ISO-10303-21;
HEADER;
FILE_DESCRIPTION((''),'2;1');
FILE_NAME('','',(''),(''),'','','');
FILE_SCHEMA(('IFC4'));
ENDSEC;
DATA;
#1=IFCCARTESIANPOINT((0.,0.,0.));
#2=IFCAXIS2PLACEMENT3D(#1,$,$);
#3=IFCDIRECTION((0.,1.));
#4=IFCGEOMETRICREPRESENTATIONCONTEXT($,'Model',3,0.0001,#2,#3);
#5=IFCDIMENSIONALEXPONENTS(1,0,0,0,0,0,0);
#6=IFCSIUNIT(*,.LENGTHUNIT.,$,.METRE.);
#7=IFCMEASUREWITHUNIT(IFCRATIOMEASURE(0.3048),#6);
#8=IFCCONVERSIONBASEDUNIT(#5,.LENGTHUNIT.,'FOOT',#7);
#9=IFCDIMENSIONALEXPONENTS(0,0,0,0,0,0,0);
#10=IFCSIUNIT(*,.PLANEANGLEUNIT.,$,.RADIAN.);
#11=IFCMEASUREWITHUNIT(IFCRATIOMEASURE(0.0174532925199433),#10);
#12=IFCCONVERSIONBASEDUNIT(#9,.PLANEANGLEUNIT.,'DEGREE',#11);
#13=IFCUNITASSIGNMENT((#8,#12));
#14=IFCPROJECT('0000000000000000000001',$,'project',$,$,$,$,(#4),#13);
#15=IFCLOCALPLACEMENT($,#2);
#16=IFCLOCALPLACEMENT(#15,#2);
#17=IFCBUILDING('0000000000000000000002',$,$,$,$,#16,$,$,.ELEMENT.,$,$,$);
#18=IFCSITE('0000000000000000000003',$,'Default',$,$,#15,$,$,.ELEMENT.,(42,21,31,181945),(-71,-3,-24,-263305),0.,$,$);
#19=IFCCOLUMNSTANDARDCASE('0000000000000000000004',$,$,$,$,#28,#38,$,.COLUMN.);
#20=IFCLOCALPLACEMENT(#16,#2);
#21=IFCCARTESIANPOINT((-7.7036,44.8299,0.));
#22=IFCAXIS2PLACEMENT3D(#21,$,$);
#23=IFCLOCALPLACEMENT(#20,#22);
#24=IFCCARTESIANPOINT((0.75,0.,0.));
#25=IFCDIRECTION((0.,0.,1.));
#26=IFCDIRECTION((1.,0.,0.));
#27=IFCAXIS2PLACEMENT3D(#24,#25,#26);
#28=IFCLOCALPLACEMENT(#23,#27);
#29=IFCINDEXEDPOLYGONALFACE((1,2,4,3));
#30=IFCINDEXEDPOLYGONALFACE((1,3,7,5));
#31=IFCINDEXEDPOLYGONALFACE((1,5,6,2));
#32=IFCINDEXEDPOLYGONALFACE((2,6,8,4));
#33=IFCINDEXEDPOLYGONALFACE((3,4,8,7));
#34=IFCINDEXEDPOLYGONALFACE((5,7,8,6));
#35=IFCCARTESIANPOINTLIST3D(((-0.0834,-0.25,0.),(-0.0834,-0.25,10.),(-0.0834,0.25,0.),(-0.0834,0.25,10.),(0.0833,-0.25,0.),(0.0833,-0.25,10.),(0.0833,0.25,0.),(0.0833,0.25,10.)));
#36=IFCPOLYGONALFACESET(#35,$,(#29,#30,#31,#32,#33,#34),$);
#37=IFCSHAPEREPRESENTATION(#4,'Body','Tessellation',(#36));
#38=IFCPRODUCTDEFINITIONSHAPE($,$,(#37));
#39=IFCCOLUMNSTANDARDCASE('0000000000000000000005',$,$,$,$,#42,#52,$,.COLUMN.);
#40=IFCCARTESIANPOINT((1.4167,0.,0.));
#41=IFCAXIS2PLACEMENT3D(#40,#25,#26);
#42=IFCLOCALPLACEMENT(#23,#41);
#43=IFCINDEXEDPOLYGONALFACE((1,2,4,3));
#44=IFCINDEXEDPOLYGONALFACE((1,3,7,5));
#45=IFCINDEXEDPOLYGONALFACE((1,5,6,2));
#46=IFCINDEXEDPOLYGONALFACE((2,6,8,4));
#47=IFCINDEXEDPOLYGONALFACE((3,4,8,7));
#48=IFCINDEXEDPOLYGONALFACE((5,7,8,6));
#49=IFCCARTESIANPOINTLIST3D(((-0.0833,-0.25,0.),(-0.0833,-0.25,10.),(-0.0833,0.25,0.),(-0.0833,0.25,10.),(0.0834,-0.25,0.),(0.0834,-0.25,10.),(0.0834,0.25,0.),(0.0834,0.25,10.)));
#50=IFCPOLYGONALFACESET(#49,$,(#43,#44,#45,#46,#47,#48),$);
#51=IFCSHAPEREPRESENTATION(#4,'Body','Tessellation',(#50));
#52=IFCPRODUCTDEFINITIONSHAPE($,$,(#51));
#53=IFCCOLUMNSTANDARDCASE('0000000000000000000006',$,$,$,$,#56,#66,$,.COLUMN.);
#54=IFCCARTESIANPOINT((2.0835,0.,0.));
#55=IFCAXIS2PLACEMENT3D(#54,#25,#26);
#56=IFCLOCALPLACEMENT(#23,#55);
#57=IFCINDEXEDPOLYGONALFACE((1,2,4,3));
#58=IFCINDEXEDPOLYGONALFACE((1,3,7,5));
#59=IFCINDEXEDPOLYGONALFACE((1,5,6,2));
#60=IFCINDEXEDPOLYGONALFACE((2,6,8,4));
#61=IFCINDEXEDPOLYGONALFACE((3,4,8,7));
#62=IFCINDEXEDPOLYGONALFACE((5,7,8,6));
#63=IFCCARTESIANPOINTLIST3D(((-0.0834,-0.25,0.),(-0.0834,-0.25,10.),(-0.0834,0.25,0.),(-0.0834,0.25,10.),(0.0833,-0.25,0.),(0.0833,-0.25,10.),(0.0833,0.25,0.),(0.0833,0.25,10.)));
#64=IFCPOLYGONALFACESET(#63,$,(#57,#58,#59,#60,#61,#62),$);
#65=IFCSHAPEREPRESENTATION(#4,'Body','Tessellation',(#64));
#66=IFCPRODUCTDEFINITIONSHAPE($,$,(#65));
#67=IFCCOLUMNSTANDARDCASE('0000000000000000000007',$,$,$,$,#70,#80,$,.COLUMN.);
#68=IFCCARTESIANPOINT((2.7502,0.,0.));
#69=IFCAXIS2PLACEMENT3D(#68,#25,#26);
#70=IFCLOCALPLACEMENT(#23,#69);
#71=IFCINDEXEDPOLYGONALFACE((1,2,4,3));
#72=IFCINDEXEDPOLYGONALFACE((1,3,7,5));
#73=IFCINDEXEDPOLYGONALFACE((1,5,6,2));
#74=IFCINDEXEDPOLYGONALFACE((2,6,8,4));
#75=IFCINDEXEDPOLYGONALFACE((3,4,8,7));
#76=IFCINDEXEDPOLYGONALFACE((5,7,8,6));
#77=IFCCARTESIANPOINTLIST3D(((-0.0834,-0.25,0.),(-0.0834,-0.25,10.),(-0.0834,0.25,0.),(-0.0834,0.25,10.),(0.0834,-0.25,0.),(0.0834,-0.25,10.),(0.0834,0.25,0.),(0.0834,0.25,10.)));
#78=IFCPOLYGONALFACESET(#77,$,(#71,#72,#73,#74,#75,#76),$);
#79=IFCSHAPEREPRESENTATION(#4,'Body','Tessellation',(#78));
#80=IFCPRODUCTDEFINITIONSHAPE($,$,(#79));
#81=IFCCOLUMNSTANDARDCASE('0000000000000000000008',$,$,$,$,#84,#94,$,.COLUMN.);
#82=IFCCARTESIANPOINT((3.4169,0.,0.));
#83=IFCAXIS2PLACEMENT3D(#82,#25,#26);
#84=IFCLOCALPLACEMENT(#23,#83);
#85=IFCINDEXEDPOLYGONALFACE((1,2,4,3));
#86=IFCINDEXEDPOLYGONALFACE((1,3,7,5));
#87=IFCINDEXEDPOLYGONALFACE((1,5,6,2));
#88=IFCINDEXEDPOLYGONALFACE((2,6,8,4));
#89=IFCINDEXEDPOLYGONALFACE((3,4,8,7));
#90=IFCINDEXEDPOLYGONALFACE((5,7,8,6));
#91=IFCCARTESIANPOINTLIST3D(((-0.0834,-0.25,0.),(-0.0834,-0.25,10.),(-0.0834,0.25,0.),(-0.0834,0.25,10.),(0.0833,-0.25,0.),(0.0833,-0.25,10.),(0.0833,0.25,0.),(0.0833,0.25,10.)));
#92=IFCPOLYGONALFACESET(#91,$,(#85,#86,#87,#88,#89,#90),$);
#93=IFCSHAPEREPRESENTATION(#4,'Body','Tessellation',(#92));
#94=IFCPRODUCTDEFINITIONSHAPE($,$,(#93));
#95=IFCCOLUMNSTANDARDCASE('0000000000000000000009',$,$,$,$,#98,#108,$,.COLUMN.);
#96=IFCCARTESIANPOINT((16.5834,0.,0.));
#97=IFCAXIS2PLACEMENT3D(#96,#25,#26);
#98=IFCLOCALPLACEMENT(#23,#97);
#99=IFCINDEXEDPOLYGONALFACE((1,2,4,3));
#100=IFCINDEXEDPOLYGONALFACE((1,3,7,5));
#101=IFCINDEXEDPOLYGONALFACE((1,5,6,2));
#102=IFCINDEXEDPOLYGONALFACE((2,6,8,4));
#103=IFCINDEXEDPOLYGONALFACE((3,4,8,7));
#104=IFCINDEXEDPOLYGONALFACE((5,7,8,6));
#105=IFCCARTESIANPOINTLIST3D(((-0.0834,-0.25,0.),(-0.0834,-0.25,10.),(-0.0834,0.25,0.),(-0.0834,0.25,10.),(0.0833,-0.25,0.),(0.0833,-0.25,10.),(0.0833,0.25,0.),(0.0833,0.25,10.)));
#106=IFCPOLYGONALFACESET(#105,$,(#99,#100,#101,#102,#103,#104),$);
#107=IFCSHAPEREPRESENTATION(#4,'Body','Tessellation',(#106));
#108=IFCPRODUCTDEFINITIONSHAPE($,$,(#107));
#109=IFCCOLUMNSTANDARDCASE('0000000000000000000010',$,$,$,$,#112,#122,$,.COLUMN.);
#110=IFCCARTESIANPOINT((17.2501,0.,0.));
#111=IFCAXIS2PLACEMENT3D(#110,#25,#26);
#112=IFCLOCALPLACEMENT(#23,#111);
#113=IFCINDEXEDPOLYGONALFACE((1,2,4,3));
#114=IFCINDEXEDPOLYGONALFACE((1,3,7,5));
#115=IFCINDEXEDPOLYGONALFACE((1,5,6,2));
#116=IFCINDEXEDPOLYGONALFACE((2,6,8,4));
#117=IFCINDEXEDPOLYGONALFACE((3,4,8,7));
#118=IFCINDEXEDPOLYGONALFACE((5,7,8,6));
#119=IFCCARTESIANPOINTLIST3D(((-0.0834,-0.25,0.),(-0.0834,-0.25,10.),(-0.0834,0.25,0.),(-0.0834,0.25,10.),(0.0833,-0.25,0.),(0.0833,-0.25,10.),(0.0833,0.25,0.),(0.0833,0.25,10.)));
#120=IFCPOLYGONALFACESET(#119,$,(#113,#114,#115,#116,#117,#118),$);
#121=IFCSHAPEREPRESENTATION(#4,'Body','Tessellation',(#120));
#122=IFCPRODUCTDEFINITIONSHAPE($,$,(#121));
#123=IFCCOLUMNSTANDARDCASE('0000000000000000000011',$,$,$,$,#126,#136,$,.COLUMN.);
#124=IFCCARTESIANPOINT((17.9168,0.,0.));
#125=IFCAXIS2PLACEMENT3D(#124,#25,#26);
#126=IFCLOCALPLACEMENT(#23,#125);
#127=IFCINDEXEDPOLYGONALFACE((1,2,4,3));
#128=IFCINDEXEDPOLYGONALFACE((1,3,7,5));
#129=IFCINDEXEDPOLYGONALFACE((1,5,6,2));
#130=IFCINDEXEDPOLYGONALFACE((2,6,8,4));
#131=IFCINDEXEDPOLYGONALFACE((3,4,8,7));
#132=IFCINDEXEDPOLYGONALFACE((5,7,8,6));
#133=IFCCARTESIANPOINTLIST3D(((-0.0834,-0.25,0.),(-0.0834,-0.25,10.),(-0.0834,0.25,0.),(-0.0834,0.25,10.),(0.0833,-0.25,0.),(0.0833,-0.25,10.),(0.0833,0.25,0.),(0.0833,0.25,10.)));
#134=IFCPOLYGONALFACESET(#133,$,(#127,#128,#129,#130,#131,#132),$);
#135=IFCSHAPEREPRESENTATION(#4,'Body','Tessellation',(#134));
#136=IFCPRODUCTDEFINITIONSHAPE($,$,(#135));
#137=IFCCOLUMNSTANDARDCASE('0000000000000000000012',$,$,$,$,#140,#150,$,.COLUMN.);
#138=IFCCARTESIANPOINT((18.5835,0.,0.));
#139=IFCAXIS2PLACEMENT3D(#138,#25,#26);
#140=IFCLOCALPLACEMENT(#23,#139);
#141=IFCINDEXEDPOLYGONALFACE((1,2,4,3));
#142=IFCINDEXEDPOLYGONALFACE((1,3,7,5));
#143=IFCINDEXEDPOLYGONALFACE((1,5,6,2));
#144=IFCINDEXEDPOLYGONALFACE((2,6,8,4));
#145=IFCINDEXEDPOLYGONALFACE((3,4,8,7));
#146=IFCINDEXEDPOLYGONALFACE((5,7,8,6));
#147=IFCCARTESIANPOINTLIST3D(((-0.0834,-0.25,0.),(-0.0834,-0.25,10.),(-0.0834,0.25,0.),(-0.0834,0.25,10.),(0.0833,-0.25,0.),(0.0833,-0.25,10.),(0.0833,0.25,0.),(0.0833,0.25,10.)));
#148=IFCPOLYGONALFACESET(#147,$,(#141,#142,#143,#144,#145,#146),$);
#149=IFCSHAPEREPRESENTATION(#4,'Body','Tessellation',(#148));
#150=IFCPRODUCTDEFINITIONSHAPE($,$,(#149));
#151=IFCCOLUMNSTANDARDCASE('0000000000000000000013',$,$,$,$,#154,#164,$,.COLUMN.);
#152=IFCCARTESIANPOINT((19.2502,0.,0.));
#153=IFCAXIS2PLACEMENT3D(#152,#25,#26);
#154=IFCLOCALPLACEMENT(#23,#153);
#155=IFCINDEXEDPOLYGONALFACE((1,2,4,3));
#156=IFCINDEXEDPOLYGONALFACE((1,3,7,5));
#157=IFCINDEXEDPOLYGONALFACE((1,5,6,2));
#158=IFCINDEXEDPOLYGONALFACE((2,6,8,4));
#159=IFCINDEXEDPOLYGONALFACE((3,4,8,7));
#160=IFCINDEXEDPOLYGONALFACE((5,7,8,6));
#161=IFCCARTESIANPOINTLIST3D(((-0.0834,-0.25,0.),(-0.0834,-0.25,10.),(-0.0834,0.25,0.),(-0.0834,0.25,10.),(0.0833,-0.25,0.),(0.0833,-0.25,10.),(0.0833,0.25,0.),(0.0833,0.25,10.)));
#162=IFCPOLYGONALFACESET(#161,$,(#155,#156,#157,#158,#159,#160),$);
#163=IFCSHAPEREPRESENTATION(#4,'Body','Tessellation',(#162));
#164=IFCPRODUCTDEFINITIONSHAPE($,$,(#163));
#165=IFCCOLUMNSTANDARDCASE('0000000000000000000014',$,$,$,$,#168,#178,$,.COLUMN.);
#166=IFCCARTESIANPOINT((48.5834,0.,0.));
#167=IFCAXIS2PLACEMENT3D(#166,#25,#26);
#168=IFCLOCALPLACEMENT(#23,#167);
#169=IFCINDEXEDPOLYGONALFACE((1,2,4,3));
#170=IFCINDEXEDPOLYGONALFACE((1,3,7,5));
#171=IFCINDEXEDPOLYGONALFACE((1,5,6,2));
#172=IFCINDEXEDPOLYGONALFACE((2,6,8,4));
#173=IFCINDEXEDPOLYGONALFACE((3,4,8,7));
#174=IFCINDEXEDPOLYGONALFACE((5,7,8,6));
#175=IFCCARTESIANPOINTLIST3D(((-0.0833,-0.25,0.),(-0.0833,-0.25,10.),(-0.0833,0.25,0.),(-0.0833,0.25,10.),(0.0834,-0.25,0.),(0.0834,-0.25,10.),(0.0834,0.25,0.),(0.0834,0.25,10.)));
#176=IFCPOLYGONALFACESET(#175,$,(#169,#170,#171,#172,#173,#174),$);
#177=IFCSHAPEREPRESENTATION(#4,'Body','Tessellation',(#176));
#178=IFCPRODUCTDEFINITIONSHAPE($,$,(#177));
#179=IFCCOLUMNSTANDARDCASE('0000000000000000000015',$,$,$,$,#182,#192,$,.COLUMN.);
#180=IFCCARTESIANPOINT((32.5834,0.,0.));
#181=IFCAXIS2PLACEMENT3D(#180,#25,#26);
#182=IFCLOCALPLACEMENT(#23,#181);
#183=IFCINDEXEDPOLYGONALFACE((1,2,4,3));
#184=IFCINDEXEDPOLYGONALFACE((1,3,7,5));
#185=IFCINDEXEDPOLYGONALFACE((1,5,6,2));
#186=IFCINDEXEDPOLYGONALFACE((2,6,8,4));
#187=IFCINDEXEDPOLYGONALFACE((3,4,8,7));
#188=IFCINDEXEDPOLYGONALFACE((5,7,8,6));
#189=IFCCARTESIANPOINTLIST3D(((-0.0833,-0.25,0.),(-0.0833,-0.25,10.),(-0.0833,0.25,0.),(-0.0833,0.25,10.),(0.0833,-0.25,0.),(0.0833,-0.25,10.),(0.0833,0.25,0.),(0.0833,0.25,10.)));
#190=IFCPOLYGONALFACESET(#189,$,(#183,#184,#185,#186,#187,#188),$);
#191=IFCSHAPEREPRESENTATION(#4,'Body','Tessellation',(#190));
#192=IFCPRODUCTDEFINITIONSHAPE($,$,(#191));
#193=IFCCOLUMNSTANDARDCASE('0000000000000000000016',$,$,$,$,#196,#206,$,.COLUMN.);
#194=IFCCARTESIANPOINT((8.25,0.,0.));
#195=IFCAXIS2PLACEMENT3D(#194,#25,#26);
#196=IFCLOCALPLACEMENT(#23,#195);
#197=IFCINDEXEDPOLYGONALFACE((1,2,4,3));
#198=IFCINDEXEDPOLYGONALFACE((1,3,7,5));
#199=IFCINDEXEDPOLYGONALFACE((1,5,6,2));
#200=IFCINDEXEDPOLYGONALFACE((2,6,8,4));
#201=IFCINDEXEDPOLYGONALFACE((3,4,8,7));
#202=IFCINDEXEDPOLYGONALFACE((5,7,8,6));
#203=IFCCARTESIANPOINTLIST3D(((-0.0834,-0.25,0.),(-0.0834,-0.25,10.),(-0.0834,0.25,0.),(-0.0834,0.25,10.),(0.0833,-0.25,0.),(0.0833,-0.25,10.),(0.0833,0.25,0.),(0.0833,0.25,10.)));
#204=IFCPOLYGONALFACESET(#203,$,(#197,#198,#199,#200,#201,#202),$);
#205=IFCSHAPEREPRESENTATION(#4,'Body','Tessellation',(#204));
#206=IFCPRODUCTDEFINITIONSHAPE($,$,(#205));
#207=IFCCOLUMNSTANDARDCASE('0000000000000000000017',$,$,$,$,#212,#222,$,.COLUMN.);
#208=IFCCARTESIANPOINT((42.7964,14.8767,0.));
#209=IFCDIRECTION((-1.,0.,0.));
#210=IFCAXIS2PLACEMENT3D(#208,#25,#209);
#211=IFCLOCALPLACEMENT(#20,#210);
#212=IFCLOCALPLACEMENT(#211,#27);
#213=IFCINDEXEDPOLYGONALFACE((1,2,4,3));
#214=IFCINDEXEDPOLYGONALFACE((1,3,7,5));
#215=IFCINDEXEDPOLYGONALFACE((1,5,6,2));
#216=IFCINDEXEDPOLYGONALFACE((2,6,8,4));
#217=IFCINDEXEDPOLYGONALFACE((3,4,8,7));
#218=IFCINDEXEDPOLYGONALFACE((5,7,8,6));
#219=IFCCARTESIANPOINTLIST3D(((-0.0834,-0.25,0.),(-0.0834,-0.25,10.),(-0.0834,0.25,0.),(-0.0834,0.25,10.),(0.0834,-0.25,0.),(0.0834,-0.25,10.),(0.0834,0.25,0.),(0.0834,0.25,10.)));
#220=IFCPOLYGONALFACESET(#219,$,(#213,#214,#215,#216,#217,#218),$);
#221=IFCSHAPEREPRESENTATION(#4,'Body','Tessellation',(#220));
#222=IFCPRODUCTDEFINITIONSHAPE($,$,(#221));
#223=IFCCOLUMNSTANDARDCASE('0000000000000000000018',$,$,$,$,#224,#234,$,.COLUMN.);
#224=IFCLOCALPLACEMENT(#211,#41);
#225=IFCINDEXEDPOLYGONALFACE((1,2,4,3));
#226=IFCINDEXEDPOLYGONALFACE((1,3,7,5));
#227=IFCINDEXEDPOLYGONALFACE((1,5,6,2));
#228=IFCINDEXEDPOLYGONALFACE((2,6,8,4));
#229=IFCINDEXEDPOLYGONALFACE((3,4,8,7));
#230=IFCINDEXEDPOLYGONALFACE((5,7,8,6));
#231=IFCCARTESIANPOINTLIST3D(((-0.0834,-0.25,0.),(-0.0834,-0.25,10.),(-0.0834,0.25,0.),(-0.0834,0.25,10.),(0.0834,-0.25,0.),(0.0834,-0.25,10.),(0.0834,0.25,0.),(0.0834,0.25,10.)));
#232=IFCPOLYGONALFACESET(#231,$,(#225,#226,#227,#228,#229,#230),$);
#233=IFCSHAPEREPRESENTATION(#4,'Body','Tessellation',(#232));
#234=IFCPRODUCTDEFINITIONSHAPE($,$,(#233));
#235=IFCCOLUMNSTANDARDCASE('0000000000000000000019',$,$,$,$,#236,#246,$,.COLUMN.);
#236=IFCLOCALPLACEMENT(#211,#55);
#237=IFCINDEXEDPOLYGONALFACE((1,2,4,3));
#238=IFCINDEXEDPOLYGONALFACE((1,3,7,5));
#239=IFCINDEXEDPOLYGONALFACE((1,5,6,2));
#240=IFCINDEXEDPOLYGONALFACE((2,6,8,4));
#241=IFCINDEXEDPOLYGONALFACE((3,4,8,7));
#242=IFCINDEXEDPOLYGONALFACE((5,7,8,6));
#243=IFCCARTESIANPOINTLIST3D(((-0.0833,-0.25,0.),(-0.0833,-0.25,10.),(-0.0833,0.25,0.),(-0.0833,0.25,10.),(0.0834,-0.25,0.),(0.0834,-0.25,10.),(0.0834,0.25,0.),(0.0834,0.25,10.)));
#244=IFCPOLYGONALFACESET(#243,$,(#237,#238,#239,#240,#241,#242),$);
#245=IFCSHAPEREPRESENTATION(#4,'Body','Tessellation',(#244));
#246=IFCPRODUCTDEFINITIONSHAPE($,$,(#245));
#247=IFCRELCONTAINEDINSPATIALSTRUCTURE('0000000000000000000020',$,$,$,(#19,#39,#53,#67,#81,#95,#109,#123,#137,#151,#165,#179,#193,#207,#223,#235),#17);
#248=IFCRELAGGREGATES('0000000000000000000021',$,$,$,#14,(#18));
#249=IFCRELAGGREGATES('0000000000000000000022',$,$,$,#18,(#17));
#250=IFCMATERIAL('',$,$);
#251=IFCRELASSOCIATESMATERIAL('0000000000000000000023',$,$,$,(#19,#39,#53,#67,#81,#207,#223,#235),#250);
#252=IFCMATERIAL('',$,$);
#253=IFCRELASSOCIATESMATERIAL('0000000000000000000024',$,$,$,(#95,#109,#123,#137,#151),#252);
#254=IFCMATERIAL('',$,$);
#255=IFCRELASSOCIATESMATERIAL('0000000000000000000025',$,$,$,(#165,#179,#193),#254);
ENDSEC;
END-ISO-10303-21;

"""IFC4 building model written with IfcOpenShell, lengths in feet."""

from ifc_helpers import new_model, entity, si_unit, converted_unit, direction, frame, origin, place, context, project, spatial, rectangle, extrude, material, element, save


model = new_model("IFC4")

# Units and contexts
model_context = context("Model", 3, precision=0.0001, world=origin(), true_north=direction((0.0, 1.0)))
ifc_project = project(units=[converted_unit("LENGTHUNIT", "FOOT", entity("IfcRatioMeasure", 0.3048), si_unit("LENGTHUNIT", "METRE"), dimensions=[1, 0, 0, 0, 0, 0, 0]), converted_unit("PLANEANGLEUNIT", "DEGREE", entity("IfcRatioMeasure", 0.0174532925199433), si_unit("PLANEANGLEUNIT", "RADIAN"), dimensions=[0, 0, 0, 0, 0, 0, 0])], contexts=[model_context])

# Site, building
site_placement = place(None, origin())
site = spatial("IfcSite", under=ifc_project, at=site_placement, Name="Default", CompositionType="ELEMENT", RefLatitude=(42, 21, 31, 181945), RefLongitude=(-71, -3, -24, -263305), RefElevation=0.0)
building_placement = place(site_placement, origin())
building = spatial("IfcBuilding", under=site, at=building_placement, CompositionType="ELEMENT")

# Columns
ifc_material_1 = material(Name="")
placement_1 = place(building_placement, origin())
placement_2 = place(placement_1, frame((-7.7036, 44.8299, 0.0)))
for number, where, z_axis, x_axis in (
    (1, (0.75, 0.0, 0.0), (0.0, 0.0, 1.0), (1.0, 0.0, 0.0)),
    (2, (1.4167, 0.0, 0.0), (0.0, 0.0, 1.0), (1.0, 0.0, 0.0)),
    (3, (2.0835, 0.0, 0.0), (0.0, 0.0, 1.0), (1.0, 0.0, 0.0)),
    (4, (2.7502, 0.0, 0.0), (0.0, 0.0, 1.0), (1.0, 0.0, 0.0)),
    (5, (3.4169, 0.0, 0.0), (0.0, 0.0, 1.0), (1.0, 0.0, 0.0)),
):
    element("IfcColumnStandardCase", number, at=place(placement_2, frame(where, z_axis=z_axis, x_axis=x_axis)), inside=building, material=ifc_material_1, PredefinedType="COLUMN", context=model_context, shape_type="SweptSolid", body=[
        extrude(rectangle(XDim=0.1667, YDim=0.5), origin(), (0.0, 0.0, 1.0), 10.0),
    ])
ifc_material_2 = material(Name="")
for number, where, z_axis, x_axis in (
    (6, (16.5834, 0.0, 0.0), (0.0, 0.0, 1.0), (1.0, 0.0, 0.0)),
    (7, (17.2501, 0.0, 0.0), (0.0, 0.0, 1.0), (1.0, 0.0, 0.0)),
    (8, (17.9168, 0.0, 0.0), (0.0, 0.0, 1.0), (1.0, 0.0, 0.0)),
    (9, (18.5835, 0.0, 0.0), (0.0, 0.0, 1.0), (1.0, 0.0, 0.0)),
    (10, (19.2502, 0.0, 0.0), (0.0, 0.0, 1.0), (1.0, 0.0, 0.0)),
):
    element("IfcColumnStandardCase", number, at=place(placement_2, frame(where, z_axis=z_axis, x_axis=x_axis)), inside=building, material=ifc_material_2, PredefinedType="COLUMN", context=model_context, shape_type="SweptSolid", body=[
        extrude(rectangle(XDim=0.1667, YDim=0.5), origin(), (0.0, 0.0, 1.0), 10.0),
    ])
ifc_material_3 = material(Name="")
for number, where, z_axis, x_axis in (
    (11, (48.5834, 0.0, 0.0), (0.0, 0.0, 1.0), (1.0, 0.0, 0.0)),
    (12, (32.5834, 0.0, 0.0), (0.0, 0.0, 1.0), (1.0, 0.0, 0.0)),
    (13, (8.25, 0.0, 0.0), (0.0, 0.0, 1.0), (1.0, 0.0, 0.0)),
):
    element("IfcColumnStandardCase", number, at=place(placement_2, frame(where, z_axis=z_axis, x_axis=x_axis)), inside=building, material=ifc_material_3, PredefinedType="COLUMN", context=model_context, shape_type="SweptSolid", body=[
        extrude(rectangle(XDim=0.1667, YDim=0.5), origin(), (0.0, 0.0, 1.0), 10.0),
    ])
placement_3 = place(placement_1, frame((42.7964, 14.8767, 0.0), z_axis=(0.0, 0.0, 1.0), x_axis=(-1.0, 0.0, 0.0)))
for number, where, z_axis, x_axis in (
    (14, (0.75, 0.0, 0.0), (0.0, 0.0, 1.0), (1.0, 0.0, 0.0)),
    (15, (1.4167, 0.0, 0.0), (0.0, 0.0, 1.0), (1.0, 0.0, 0.0)),
    (16, (2.0835, 0.0, 0.0), (0.0, 0.0, 1.0), (1.0, 0.0, 0.0)),
):
    element("IfcColumnStandardCase", number, at=place(placement_3, frame(where, z_axis=z_axis, x_axis=x_axis)), inside=building, material=ifc_material_1, PredefinedType="COLUMN", context=model_context, shape_type="SweptSolid", body=[
        extrude(rectangle(XDim=0.1667, YDim=0.5), origin(), (0.0, 0.0, 1.0), 10.0),
    ])

save(model, "model.ifc")
